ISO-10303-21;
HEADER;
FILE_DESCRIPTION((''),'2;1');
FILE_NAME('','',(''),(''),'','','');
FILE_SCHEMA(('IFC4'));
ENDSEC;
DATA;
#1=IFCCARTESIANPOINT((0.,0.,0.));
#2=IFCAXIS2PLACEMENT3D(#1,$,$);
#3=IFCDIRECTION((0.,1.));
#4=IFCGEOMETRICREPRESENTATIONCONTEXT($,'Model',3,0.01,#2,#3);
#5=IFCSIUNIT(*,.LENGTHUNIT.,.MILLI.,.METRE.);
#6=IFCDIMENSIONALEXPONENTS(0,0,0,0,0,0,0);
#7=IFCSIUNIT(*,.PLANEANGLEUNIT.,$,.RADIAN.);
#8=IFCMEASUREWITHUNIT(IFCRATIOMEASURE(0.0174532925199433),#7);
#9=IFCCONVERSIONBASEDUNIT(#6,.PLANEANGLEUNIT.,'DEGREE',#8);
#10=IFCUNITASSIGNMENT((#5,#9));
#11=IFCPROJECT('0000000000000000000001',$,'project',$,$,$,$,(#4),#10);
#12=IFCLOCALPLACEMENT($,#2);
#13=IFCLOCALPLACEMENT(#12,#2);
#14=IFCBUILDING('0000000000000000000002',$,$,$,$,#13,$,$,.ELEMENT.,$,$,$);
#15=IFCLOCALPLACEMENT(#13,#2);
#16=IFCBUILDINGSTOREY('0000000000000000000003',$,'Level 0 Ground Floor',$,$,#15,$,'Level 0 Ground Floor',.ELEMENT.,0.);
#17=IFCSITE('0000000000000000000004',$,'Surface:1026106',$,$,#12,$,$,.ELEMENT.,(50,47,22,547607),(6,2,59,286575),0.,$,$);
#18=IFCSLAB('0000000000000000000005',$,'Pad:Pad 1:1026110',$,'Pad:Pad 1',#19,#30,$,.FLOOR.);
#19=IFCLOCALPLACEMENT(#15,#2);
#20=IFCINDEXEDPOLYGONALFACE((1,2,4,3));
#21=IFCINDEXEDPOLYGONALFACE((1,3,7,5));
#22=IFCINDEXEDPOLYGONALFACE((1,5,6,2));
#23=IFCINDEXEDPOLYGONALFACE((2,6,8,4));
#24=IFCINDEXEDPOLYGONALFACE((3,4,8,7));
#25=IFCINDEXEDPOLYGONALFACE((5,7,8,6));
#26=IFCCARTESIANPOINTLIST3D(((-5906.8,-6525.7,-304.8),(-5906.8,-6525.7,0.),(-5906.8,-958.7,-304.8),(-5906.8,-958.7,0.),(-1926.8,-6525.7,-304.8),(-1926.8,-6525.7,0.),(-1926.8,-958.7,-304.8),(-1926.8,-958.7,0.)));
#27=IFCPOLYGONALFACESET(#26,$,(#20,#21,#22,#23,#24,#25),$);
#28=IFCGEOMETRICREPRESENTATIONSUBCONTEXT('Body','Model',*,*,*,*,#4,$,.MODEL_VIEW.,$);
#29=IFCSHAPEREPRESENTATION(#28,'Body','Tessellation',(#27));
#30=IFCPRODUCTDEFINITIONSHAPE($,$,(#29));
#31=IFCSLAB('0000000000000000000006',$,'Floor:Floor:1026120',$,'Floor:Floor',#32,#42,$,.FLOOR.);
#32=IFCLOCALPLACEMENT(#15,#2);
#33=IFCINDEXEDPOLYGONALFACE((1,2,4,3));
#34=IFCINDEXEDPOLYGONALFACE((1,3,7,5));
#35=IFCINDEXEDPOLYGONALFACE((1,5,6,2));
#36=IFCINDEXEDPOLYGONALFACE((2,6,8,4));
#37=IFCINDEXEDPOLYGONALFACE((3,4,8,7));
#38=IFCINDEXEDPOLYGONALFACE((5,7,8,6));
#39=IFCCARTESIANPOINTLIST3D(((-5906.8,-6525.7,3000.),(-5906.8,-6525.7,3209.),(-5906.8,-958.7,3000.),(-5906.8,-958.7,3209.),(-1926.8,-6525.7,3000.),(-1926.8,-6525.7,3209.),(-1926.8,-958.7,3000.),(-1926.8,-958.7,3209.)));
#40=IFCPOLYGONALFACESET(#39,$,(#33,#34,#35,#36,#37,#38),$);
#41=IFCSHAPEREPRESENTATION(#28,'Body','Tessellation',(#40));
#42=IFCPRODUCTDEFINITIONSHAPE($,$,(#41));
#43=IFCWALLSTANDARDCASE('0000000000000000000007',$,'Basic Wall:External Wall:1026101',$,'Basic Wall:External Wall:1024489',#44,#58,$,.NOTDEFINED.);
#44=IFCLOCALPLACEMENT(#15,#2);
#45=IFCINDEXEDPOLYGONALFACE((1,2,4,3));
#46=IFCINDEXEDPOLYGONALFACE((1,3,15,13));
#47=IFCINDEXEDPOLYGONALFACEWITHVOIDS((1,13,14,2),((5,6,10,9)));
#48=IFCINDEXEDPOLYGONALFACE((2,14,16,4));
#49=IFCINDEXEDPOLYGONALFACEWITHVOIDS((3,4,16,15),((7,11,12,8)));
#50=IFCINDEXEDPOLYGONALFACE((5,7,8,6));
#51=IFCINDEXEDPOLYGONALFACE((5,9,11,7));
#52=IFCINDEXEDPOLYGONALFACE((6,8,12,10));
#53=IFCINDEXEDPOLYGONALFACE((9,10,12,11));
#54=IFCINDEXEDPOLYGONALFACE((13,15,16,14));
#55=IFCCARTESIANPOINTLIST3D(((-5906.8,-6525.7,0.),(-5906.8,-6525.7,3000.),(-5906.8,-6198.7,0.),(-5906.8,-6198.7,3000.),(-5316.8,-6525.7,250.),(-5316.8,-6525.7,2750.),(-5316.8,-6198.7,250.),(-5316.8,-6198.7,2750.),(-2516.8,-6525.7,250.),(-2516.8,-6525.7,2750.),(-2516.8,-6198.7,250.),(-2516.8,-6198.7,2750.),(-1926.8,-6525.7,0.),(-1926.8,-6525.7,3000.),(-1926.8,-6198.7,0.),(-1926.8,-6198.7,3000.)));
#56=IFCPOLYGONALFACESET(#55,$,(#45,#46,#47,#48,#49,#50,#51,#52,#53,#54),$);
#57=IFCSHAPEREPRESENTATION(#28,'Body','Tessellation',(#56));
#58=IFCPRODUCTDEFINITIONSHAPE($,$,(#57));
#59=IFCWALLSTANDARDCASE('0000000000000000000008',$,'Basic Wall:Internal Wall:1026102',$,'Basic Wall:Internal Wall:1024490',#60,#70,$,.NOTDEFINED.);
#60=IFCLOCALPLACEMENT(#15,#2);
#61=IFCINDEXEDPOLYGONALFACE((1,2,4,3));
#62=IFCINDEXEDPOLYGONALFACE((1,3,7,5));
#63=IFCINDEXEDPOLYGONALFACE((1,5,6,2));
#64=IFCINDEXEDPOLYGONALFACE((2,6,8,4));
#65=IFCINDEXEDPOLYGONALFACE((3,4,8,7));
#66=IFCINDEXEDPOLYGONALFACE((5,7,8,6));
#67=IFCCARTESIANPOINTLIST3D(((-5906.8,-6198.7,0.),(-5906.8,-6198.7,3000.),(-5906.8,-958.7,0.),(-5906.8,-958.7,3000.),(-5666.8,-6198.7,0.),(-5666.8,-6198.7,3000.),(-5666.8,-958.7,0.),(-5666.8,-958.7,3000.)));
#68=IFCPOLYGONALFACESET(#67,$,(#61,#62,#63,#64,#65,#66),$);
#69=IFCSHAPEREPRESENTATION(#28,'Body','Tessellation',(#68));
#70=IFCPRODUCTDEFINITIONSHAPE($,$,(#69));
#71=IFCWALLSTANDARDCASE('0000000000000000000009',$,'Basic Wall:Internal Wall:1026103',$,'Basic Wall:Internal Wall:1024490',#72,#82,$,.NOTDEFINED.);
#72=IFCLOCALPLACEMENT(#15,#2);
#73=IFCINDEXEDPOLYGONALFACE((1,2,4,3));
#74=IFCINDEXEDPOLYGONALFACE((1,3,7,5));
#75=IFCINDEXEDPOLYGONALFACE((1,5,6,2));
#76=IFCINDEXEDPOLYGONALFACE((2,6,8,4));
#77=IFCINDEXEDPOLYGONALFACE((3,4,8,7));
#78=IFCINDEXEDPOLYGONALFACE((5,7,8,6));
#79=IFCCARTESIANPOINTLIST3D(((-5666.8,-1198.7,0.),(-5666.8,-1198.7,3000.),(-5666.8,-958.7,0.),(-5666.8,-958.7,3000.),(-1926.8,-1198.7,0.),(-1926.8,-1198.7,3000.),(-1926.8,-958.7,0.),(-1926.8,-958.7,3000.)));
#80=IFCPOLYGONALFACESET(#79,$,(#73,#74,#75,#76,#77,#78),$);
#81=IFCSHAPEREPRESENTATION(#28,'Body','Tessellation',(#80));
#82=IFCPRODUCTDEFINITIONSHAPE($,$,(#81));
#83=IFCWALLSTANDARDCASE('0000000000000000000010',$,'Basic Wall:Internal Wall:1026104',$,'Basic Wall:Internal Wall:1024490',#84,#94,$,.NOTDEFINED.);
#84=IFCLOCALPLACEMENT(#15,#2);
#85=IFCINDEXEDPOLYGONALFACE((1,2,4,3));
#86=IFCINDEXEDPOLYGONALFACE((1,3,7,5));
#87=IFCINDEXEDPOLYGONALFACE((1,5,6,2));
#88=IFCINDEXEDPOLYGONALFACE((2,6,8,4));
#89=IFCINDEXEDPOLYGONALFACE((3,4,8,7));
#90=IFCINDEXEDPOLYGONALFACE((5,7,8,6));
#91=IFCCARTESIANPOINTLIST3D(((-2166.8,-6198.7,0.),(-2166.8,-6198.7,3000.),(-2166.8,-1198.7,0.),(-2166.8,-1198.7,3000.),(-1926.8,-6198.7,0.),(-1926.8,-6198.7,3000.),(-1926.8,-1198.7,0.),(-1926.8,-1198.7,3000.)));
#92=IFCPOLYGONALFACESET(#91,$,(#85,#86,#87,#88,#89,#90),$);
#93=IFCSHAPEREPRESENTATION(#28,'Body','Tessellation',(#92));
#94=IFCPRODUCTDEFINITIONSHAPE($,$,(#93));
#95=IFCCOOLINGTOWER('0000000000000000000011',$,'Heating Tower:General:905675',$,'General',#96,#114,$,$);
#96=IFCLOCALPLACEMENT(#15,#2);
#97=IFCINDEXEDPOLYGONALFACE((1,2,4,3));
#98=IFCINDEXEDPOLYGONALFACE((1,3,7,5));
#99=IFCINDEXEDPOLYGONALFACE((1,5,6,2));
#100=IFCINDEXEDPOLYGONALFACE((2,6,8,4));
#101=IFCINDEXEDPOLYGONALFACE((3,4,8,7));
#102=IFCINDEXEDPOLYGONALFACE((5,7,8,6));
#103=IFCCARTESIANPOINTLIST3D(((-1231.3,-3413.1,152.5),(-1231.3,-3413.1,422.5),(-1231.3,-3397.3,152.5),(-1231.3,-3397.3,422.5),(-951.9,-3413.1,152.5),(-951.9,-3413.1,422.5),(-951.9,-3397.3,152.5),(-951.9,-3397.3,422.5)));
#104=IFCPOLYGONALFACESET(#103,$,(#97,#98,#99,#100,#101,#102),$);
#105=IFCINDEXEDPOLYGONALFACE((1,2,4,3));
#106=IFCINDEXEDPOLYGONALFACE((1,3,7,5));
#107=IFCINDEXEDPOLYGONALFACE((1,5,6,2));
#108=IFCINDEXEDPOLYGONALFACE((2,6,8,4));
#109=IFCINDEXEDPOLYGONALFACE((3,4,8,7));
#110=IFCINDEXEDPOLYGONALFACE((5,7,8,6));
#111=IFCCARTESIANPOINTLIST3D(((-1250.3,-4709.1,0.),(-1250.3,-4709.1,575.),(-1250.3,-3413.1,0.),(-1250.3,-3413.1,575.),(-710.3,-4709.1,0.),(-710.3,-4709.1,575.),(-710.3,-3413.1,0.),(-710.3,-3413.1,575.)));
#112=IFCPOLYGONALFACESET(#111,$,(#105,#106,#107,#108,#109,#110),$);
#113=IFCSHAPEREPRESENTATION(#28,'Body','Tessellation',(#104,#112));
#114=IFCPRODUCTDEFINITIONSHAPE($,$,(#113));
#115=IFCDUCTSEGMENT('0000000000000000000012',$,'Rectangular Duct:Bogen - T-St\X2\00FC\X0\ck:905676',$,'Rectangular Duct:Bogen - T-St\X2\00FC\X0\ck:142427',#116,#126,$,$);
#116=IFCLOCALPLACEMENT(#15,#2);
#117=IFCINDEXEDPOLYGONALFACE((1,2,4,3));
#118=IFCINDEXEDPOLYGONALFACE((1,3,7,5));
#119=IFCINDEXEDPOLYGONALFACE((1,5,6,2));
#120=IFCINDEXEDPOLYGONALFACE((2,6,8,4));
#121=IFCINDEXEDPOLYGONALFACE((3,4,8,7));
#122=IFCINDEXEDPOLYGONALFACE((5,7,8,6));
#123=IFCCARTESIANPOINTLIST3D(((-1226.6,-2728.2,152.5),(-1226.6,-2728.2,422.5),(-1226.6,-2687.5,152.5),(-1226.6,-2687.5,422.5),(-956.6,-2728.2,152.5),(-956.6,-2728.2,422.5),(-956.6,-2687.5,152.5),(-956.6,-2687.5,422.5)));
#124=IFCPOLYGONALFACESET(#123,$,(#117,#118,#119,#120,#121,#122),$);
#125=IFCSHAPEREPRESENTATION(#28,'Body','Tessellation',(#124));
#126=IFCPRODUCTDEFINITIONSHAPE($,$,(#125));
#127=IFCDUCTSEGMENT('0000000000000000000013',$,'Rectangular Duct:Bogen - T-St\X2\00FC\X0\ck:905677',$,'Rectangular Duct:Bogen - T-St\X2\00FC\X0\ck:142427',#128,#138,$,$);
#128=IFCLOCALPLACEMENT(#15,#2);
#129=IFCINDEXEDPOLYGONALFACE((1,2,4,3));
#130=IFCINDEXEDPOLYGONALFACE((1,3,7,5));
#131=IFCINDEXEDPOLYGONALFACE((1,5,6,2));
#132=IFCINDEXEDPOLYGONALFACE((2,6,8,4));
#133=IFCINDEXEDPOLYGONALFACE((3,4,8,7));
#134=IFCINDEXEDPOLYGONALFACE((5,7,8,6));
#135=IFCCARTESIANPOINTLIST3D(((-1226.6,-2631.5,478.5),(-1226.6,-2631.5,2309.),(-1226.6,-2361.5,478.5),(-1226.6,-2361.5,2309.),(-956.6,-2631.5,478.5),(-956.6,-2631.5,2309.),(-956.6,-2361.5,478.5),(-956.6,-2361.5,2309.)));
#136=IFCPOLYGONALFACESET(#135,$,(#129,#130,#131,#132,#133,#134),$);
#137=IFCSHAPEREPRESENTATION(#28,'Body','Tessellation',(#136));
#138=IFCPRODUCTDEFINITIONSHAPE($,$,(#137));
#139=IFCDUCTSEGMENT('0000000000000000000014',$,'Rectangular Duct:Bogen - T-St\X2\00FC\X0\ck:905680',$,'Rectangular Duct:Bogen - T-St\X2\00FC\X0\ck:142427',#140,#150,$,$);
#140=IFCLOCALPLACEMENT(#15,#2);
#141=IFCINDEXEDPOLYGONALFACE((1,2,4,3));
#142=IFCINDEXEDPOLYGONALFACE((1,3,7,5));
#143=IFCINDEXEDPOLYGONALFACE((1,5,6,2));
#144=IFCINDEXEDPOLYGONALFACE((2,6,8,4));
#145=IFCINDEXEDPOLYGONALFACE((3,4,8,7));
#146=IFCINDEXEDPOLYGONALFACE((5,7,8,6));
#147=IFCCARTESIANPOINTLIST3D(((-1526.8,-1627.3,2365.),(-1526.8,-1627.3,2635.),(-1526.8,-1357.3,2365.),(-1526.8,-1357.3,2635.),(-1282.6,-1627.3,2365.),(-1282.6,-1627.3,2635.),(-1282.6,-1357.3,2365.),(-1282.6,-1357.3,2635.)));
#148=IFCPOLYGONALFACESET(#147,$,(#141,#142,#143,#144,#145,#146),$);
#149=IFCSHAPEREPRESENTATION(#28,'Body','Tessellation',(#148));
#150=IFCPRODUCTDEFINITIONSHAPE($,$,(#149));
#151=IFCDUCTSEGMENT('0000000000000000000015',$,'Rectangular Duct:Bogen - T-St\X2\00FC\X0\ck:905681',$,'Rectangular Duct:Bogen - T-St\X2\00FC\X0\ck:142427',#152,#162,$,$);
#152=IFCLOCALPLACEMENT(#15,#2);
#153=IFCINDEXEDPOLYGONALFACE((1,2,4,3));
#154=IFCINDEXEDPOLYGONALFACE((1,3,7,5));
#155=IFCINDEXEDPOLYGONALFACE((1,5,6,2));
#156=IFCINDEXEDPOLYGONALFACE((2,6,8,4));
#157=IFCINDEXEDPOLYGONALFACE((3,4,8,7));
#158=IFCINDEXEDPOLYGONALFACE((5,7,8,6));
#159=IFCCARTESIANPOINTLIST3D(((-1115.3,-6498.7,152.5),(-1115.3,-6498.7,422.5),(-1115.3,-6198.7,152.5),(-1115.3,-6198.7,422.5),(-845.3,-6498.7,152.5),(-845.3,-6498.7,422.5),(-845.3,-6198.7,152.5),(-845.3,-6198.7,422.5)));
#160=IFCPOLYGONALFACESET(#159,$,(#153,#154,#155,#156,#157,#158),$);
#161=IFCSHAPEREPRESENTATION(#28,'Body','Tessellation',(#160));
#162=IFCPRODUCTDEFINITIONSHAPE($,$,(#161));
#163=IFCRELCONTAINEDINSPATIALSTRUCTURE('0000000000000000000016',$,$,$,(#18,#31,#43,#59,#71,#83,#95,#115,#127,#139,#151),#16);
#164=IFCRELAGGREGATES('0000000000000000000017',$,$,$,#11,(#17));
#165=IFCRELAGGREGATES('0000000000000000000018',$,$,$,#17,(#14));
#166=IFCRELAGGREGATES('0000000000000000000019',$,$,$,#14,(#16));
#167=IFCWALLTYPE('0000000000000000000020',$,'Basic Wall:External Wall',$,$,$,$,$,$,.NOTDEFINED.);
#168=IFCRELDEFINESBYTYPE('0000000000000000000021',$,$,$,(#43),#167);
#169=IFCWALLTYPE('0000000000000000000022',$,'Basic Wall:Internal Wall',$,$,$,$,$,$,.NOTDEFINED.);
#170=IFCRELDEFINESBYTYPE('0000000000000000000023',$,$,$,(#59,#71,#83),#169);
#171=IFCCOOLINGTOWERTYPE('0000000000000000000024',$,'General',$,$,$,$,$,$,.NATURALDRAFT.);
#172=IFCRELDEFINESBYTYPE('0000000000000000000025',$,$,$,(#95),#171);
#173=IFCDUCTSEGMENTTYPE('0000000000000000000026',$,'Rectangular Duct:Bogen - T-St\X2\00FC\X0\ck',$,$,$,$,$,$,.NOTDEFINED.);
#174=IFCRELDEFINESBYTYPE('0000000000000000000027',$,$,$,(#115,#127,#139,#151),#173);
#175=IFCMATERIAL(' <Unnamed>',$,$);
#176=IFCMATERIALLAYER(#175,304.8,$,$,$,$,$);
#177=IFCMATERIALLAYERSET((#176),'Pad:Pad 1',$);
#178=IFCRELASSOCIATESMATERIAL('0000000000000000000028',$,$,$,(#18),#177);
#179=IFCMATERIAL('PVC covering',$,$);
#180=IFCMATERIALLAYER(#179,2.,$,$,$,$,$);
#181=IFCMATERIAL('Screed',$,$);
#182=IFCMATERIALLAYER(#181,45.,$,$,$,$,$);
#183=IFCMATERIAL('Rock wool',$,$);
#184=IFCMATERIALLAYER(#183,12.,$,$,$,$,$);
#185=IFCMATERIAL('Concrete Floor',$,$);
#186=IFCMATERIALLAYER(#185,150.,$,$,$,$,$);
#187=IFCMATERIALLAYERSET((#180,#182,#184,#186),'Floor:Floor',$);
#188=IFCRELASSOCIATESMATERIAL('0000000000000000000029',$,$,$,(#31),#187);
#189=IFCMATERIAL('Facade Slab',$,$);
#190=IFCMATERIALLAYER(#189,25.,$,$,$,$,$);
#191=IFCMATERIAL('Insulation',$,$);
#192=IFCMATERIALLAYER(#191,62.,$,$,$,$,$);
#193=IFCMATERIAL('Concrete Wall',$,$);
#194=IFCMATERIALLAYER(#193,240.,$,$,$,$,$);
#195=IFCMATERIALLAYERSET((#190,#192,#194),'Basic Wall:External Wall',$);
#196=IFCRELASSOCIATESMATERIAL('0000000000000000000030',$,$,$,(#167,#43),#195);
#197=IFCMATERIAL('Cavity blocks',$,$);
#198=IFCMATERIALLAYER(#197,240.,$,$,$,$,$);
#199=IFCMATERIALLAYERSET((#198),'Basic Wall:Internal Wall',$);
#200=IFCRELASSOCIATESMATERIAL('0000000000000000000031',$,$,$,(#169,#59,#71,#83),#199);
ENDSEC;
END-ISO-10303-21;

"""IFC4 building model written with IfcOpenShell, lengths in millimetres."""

from ifc_helpers import new_model, entity, si_unit, converted_unit, direction, frame, frame_2d, origin, origin_2d_with_axis, place, context, subcontext, project, spatial, polyline, rectangle, extrude, clip, bounded_halfspace, source, transform, mapped, material, layer, layer_set, layer_usage, type_object, type_shapes, element, save


model = new_model("IFC4")

# Units and contexts
model_context = context("Model", 3, precision=0.01, world=origin(), true_north=direction((0.0, 1.0)))
body_context = subcontext(model_context, "Body", "Model", "MODEL_VIEW")
ifc_project = project(units=[si_unit("LENGTHUNIT", "METRE", prefix="MILLI"), converted_unit("PLANEANGLEUNIT", "DEGREE", entity("IfcRatioMeasure", 0.0174532925199433), si_unit("PLANEANGLEUNIT", "RADIAN"), dimensions=[0, 0, 0, 0, 0, 0, 0])], contexts=[model_context])

# Site, building, storey
site_placement = place(None, origin())
site = spatial("IfcSite", under=ifc_project, at=site_placement, Name="Surface:1026106", CompositionType="ELEMENT", RefLatitude=(50, 47, 22, 547607), RefLongitude=(6, 2, 59, 286575), RefElevation=0.0)
building_placement = place(site_placement, origin())
building = spatial("IfcBuilding", under=site, at=building_placement, CompositionType="ELEMENT")
storey_placement = place(building_placement, origin())
storey = spatial("IfcBuildingStorey", under=building, at=storey_placement, Name="Level 0 Ground Floor", LongName="Level 0 Ground Floor", CompositionType="ELEMENT", Elevation=0.0)

# Slabs
ifc_material_1 = material(Name=" <Unnamed>")
ifc_layer_1 = layer(ifc_material_1, 304.8)
ifc_layer_set_1 = layer_set([ifc_layer_1], Name="Pad:Pad 1")
ifc_layer_usage_1 = layer_usage(ifc_layer_set_1, "AXIS3", "NEGATIVE", 0.0)
slab_1_placement = place(storey_placement, frame((-5906.8, -6525.7, -304.8)))
element("IfcSlab", 1, at=slab_1_placement, inside=storey, material=ifc_layer_usage_1, Name="Pad:Pad 1:1026110", ObjectType="Pad:Pad 1", PredefinedType="FLOOR", context=body_context, shape_type="SweptSolid", body=[
    extrude(rectangle(XDim=5567.0, YDim=3980.0, at=frame_2d((0.0, 0.0), x_axis=(0.0, -1.0))), frame((1990.0, 2783.5, 304.8), z_axis=(0.0, 0.0, -1.0), x_axis=(-1.0, 0.0, 0.0)), (0.0, 0.0, 1.0), 304.8),
])
ifc_material_2 = material(Name="PVC covering")
ifc_layer_2 = layer(ifc_material_2, 2.0)
ifc_material_3 = material(Name="Screed")
ifc_layer_3 = layer(ifc_material_3, 45.0)
ifc_material_4 = material(Name="Rock wool")
ifc_layer_4 = layer(ifc_material_4, 12.0)
ifc_material_5 = material(Name="Concrete Floor")
ifc_layer_5 = layer(ifc_material_5, 150.0)
ifc_layer_set_2 = layer_set([ifc_layer_2, ifc_layer_3, ifc_layer_4, ifc_layer_5], Name="Floor:Floor")
ifc_layer_usage_2 = layer_usage(ifc_layer_set_2, "AXIS3", "POSITIVE", 0.0)
slab_2_placement = place(storey_placement, origin())
element("IfcSlab", 2, at=slab_2_placement, inside=storey, material=ifc_layer_usage_2, Name="Floor:Floor:1026120", ObjectType="Floor:Floor", PredefinedType="FLOOR", context=body_context, shape_type="SweptSolid", body=[
    extrude(rectangle(XDim=5567.0, YDim=3980.0, at=frame_2d((0.0, 0.0), x_axis=(1.0, 0.0))), frame((-3916.8, -3742.2, 3209.0), z_axis=(0.0, 0.0, -1.0), x_axis=(0.0, 1.0, 0.0)), (0.0, 0.0, 1.0), 209.0),
])

# Wall, opening
ifc_material_6 = material(Name="Facade Slab")
ifc_layer_6 = layer(ifc_material_6, 25.0)
ifc_material_7 = material(Name="Insulation")
ifc_layer_7 = layer(ifc_material_7, 62.0)
ifc_material_8 = material(Name="Concrete Wall")
ifc_layer_8 = layer(ifc_material_8, 240.0)
ifc_layer_set_3 = layer_set([ifc_layer_6, ifc_layer_7, ifc_layer_8], Name="Basic Wall:External Wall")
ifc_layer_usage_3 = layer_usage(ifc_layer_set_3, "AXIS2", "POSITIVE", -163.5)
wall_type_1 = type_object("IfcWallType", Name="Basic Wall:External Wall", PredefinedType="NOTDEFINED", material=ifc_layer_set_3)
wall_1_placement = place(storey_placement, frame((-5906.8, -6362.2, 0.0)))
wall_1 = element("IfcWallStandardCase", 3, at=wall_1_placement, inside=storey, type_object=wall_type_1, material=ifc_layer_usage_3, Name="Basic Wall:External Wall:1026101", ObjectType="Basic Wall:External Wall:1024489", PredefinedType="NOTDEFINED", context=body_context, shape_type="Clipping", body=[
    clip(extrude(rectangle(XDim=3980.0, YDim=327.0, at=frame_2d((1990.0, 0.0), x_axis=(-1.0, 0.0))), origin(), (0.0, 0.0, 1.0), 3000.0), bounded_halfspace(frame((0.0, -163.5, 3000.0), z_axis=(0.0, 0.0, -1.0), x_axis=(0.0, -1.0, 0.0)), True, frame((0.0, -163.5, 3000.0)), polyline([(0.0, 0.0), (3980.0, 0.0), (3980.0, 327.0), (3740.0, 327.0), (240.0, 327.0), (0.0, 327.0), (0.0, 0.0)]))),
])
opening_placement = place(wall_1_placement, frame((590.0, -163.5, 250.0)))
element("IfcOpeningElement", 4, at=opening_placement, cuts=wall_1, ObjectType="Opening", PredefinedType="OPENING", context=body_context, shape_type="SweptSolid", body=[
    extrude(rectangle(XDim=2500.0, YDim=2800.0, at=frame_2d((1250.0, 1400.0), x_axis=(1.0, 0.0))), frame((0.0, 0.0, 0.0), z_axis=(0.0, 1.0, 0.0), x_axis=(0.0, 0.0, 1.0)), (0.0, 0.0, 1.0), 327.0),
])

# Walls
ifc_material_9 = material(Name="Cavity blocks")
ifc_layer_9 = layer(ifc_material_9, 240.0)
ifc_layer_set_4 = layer_set([ifc_layer_9], Name="Basic Wall:Internal Wall")
ifc_layer_usage_4 = layer_usage(ifc_layer_set_4, "AXIS2", "NEGATIVE", 120.0)
wall_type_2 = type_object("IfcWallType", Name="Basic Wall:Internal Wall", PredefinedType="NOTDEFINED", material=ifc_layer_set_4)
wall_2_placement = place(storey_placement, frame((-5786.8, -6198.7, 0.0), z_axis=(0.0, 0.0, 1.0), x_axis=(0.0, 1.0, 0.0)))
element("IfcWallStandardCase", 5, at=wall_2_placement, inside=storey, type_object=wall_type_2, material=ifc_layer_usage_4, Name="Basic Wall:Internal Wall:1026102", ObjectType="Basic Wall:Internal Wall:1024490", PredefinedType="NOTDEFINED", context=body_context, shape_type="Clipping", body=[
    clip(extrude(rectangle(XDim=5240.0, YDim=240.0, at=frame_2d((2620.0, 0.0), x_axis=(-1.0, 0.0))), origin(), (0.0, 0.0, 1.0), 3000.0), bounded_halfspace(frame((0.0, -120.0, 3000.0), z_axis=(0.0, 0.0, -1.0), x_axis=(-1.0, 0.0, 0.0)), True, frame((0.0, -120.0, 3000.0)), polyline([(0.0, 0.0), (5000.0, 0.0), (5240.0, 0.0), (5240.0, 240.0), (0.0, 240.0), (0.0, 0.0)]))),
])
ifc_layer_usage_5 = layer_usage(ifc_layer_set_4, "AXIS2", "NEGATIVE", 120.0)
wall_3_placement = place(storey_placement, frame((-5666.8, -1078.7, 0.0)))
element("IfcWallStandardCase", 6, at=wall_3_placement, inside=storey, type_object=wall_type_2, material=ifc_layer_usage_5, Name="Basic Wall:Internal Wall:1026103", ObjectType="Basic Wall:Internal Wall:1024490", PredefinedType="NOTDEFINED", context=body_context, shape_type="Clipping", body=[
    clip(extrude(rectangle(XDim=3740.0, YDim=240.0, at=frame_2d((1870.0, 0.0), x_axis=(-1.0, 0.0))), origin(), (0.0, 0.0, 1.0), 3000.0), bounded_halfspace(frame((0.0, -120.0, 3000.0), z_axis=(0.0, 0.0, -1.0), x_axis=(0.0, -1.0, 0.0)), True, frame((0.0, -120.0, 3000.0)), polyline([(0.0, 0.0), (3500.0, 0.0), (3740.0, 0.0), (3740.0, 240.0), (0.0, 240.0), (0.0, 0.0)]))),
])
ifc_layer_usage_6 = layer_usage(ifc_layer_set_4, "AXIS2", "NEGATIVE", 120.0)
wall_4_placement = place(storey_placement, frame((-2046.8, -1198.7, 0.0), z_axis=(0.0, 0.0, 1.0), x_axis=(0.0, -1.0, 0.0)))
element("IfcWallStandardCase", 7, at=wall_4_placement, inside=storey, type_object=wall_type_2, material=ifc_layer_usage_6, Name="Basic Wall:Internal Wall:1026104", ObjectType="Basic Wall:Internal Wall:1024490", PredefinedType="NOTDEFINED", context=body_context, shape_type="Clipping", body=[
    clip(extrude(rectangle(XDim=5000.0, YDim=240.0, at=frame_2d((2500.0, 0.0), x_axis=(-1.0, 0.0))), origin(), (0.0, 0.0, 1.0), 3000.0), bounded_halfspace(frame((0.0, -120.0, 3000.0), z_axis=(0.0, 0.0, -1.0), x_axis=(1.0, 0.0, 0.0)), True, frame((0.0, -120.0, 3000.0)), polyline([(0.0, 0.0), (5000.0, 0.0), (5000.0, 240.0), (0.0, 240.0), (0.0, 0.0)]))),
])

# Cooling tower
cooling_tower_type = type_object("IfcCoolingTowerType", Name="General", PredefinedType="NATURALDRAFT")
shared_shape_1 = source(origin(), body_context, "Body", "SweptSolid", [
    extrude(rectangle(XDim=15.9, YDim=279.4, at=frame_2d((0.0, 0.0), x_axis=(1.0, 0.0))), frame((1303.9, 381.3, 152.5)), (0.0, 0.0, 1.0), 270.0),
    extrude(rectangle(XDim=1296.0, YDim=540.0, at=origin_2d_with_axis()), frame((648.0, 270.0, 0.0), z_axis=(0.0, 0.0, 1.0), x_axis=(-1.0, 0.0, 0.0)), (0.0, 0.0, 1.0), 575.0),
])
type_shapes(cooling_tower_type, [shared_shape_1])
cooling_tower_placement = place(storey_placement, frame((-710.3, -4709.1, 0.0), z_axis=(0.0, 0.0, 1.0), x_axis=(0.0, 1.0, 0.0)))
element("IfcCoolingTower", 8, at=cooling_tower_placement, inside=storey, type_object=cooling_tower_type, Name="Heating Tower:General:905675", ObjectType="General", context=body_context, shape_type="MappedRepresentation", body=[
    mapped(shared_shape_1, transform((0.0, 0.0, 0.0), scale=1.0)),
])

# Duct segments
duct_segment_type = type_object("IfcDuctSegmentType", Name="Rectangular Duct:Bogen - T-Stück", PredefinedType="NOTDEFINED")
duct_segment_1_placement = place(storey_placement, frame((-1226.6, -2728.2, 152.5)))
element("IfcDuctSegment", 9, at=duct_segment_1_placement, inside=storey, type_object=duct_segment_type, Name="Rectangular Duct:Bogen - T-Stück:905676", ObjectType="Rectangular Duct:Bogen - T-Stück:142427", context=body_context, shape_type="SweptSolid", body=[
    extrude(rectangle(XDim=40.7, YDim=270.0, at=frame_2d((0.0, 0.0), x_axis=(1.0, 0.0))), frame((135.0, 20.4, 0.0), z_axis=(0.0, 0.0, 1.0), x_axis=(0.0, -1.0, 0.0)), (0.0, 0.0, 1.0), 270.0),
])
duct_segment_2_placement = place(storey_placement, frame((-1226.6, -2631.5, 478.5)))
element("IfcDuctSegment", 10, at=duct_segment_2_placement, inside=storey, type_object=duct_segment_type, Name="Rectangular Duct:Bogen - T-Stück:905677", ObjectType="Rectangular Duct:Bogen - T-Stück:142427", context=body_context, shape_type="SweptSolid", body=[
    extrude(rectangle(XDim=270.0, YDim=270.0, at=frame_2d((0.0, 0.0), x_axis=(1.0, 0.0))), frame((135.0, 135.0, 0.0), z_axis=(0.0, 0.0, 1.0), x_axis=(0.0, -1.0, 0.0)), (0.0, 0.0, 1.0), 1830.5),
])
duct_segment_3_placement = place(storey_placement, frame((-1526.8, -1627.3, 2365.0)))
element("IfcDuctSegment", 11, at=duct_segment_3_placement, inside=storey, type_object=duct_segment_type, Name="Rectangular Duct:Bogen - T-Stück:905680", ObjectType="Rectangular Duct:Bogen - T-Stück:142427", context=body_context, shape_type="SweptSolid", body=[
    extrude(rectangle(XDim=244.2, YDim=270.0, at=frame_2d((0.0, 0.0), x_axis=(1.0, 0.0))), frame((122.1, 135.0, 0.0), z_axis=(0.0, 0.0, 1.0), x_axis=(-1.0, 0.0, 0.0)), (0.0, 0.0, 1.0), 270.0),
])
duct_segment_4_placement = place(storey_placement, frame((-1115.3, -6498.7, 152.5)))
element("IfcDuctSegment", 12, at=duct_segment_4_placement, inside=storey, type_object=duct_segment_type, Name="Rectangular Duct:Bogen - T-Stück:905681", ObjectType="Rectangular Duct:Bogen - T-Stück:142427", context=body_context, shape_type="SweptSolid", body=[
    extrude(rectangle(XDim=300.0, YDim=270.0, at=frame_2d((0.0, 0.0), x_axis=(1.0, 0.0))), frame((135.0, 150.0, 0.0), z_axis=(0.0, 0.0, 1.0), x_axis=(0.0, -1.0, 0.0)), (0.0, 0.0, 1.0), 270.0),
])

save(model, "model.ifc")
